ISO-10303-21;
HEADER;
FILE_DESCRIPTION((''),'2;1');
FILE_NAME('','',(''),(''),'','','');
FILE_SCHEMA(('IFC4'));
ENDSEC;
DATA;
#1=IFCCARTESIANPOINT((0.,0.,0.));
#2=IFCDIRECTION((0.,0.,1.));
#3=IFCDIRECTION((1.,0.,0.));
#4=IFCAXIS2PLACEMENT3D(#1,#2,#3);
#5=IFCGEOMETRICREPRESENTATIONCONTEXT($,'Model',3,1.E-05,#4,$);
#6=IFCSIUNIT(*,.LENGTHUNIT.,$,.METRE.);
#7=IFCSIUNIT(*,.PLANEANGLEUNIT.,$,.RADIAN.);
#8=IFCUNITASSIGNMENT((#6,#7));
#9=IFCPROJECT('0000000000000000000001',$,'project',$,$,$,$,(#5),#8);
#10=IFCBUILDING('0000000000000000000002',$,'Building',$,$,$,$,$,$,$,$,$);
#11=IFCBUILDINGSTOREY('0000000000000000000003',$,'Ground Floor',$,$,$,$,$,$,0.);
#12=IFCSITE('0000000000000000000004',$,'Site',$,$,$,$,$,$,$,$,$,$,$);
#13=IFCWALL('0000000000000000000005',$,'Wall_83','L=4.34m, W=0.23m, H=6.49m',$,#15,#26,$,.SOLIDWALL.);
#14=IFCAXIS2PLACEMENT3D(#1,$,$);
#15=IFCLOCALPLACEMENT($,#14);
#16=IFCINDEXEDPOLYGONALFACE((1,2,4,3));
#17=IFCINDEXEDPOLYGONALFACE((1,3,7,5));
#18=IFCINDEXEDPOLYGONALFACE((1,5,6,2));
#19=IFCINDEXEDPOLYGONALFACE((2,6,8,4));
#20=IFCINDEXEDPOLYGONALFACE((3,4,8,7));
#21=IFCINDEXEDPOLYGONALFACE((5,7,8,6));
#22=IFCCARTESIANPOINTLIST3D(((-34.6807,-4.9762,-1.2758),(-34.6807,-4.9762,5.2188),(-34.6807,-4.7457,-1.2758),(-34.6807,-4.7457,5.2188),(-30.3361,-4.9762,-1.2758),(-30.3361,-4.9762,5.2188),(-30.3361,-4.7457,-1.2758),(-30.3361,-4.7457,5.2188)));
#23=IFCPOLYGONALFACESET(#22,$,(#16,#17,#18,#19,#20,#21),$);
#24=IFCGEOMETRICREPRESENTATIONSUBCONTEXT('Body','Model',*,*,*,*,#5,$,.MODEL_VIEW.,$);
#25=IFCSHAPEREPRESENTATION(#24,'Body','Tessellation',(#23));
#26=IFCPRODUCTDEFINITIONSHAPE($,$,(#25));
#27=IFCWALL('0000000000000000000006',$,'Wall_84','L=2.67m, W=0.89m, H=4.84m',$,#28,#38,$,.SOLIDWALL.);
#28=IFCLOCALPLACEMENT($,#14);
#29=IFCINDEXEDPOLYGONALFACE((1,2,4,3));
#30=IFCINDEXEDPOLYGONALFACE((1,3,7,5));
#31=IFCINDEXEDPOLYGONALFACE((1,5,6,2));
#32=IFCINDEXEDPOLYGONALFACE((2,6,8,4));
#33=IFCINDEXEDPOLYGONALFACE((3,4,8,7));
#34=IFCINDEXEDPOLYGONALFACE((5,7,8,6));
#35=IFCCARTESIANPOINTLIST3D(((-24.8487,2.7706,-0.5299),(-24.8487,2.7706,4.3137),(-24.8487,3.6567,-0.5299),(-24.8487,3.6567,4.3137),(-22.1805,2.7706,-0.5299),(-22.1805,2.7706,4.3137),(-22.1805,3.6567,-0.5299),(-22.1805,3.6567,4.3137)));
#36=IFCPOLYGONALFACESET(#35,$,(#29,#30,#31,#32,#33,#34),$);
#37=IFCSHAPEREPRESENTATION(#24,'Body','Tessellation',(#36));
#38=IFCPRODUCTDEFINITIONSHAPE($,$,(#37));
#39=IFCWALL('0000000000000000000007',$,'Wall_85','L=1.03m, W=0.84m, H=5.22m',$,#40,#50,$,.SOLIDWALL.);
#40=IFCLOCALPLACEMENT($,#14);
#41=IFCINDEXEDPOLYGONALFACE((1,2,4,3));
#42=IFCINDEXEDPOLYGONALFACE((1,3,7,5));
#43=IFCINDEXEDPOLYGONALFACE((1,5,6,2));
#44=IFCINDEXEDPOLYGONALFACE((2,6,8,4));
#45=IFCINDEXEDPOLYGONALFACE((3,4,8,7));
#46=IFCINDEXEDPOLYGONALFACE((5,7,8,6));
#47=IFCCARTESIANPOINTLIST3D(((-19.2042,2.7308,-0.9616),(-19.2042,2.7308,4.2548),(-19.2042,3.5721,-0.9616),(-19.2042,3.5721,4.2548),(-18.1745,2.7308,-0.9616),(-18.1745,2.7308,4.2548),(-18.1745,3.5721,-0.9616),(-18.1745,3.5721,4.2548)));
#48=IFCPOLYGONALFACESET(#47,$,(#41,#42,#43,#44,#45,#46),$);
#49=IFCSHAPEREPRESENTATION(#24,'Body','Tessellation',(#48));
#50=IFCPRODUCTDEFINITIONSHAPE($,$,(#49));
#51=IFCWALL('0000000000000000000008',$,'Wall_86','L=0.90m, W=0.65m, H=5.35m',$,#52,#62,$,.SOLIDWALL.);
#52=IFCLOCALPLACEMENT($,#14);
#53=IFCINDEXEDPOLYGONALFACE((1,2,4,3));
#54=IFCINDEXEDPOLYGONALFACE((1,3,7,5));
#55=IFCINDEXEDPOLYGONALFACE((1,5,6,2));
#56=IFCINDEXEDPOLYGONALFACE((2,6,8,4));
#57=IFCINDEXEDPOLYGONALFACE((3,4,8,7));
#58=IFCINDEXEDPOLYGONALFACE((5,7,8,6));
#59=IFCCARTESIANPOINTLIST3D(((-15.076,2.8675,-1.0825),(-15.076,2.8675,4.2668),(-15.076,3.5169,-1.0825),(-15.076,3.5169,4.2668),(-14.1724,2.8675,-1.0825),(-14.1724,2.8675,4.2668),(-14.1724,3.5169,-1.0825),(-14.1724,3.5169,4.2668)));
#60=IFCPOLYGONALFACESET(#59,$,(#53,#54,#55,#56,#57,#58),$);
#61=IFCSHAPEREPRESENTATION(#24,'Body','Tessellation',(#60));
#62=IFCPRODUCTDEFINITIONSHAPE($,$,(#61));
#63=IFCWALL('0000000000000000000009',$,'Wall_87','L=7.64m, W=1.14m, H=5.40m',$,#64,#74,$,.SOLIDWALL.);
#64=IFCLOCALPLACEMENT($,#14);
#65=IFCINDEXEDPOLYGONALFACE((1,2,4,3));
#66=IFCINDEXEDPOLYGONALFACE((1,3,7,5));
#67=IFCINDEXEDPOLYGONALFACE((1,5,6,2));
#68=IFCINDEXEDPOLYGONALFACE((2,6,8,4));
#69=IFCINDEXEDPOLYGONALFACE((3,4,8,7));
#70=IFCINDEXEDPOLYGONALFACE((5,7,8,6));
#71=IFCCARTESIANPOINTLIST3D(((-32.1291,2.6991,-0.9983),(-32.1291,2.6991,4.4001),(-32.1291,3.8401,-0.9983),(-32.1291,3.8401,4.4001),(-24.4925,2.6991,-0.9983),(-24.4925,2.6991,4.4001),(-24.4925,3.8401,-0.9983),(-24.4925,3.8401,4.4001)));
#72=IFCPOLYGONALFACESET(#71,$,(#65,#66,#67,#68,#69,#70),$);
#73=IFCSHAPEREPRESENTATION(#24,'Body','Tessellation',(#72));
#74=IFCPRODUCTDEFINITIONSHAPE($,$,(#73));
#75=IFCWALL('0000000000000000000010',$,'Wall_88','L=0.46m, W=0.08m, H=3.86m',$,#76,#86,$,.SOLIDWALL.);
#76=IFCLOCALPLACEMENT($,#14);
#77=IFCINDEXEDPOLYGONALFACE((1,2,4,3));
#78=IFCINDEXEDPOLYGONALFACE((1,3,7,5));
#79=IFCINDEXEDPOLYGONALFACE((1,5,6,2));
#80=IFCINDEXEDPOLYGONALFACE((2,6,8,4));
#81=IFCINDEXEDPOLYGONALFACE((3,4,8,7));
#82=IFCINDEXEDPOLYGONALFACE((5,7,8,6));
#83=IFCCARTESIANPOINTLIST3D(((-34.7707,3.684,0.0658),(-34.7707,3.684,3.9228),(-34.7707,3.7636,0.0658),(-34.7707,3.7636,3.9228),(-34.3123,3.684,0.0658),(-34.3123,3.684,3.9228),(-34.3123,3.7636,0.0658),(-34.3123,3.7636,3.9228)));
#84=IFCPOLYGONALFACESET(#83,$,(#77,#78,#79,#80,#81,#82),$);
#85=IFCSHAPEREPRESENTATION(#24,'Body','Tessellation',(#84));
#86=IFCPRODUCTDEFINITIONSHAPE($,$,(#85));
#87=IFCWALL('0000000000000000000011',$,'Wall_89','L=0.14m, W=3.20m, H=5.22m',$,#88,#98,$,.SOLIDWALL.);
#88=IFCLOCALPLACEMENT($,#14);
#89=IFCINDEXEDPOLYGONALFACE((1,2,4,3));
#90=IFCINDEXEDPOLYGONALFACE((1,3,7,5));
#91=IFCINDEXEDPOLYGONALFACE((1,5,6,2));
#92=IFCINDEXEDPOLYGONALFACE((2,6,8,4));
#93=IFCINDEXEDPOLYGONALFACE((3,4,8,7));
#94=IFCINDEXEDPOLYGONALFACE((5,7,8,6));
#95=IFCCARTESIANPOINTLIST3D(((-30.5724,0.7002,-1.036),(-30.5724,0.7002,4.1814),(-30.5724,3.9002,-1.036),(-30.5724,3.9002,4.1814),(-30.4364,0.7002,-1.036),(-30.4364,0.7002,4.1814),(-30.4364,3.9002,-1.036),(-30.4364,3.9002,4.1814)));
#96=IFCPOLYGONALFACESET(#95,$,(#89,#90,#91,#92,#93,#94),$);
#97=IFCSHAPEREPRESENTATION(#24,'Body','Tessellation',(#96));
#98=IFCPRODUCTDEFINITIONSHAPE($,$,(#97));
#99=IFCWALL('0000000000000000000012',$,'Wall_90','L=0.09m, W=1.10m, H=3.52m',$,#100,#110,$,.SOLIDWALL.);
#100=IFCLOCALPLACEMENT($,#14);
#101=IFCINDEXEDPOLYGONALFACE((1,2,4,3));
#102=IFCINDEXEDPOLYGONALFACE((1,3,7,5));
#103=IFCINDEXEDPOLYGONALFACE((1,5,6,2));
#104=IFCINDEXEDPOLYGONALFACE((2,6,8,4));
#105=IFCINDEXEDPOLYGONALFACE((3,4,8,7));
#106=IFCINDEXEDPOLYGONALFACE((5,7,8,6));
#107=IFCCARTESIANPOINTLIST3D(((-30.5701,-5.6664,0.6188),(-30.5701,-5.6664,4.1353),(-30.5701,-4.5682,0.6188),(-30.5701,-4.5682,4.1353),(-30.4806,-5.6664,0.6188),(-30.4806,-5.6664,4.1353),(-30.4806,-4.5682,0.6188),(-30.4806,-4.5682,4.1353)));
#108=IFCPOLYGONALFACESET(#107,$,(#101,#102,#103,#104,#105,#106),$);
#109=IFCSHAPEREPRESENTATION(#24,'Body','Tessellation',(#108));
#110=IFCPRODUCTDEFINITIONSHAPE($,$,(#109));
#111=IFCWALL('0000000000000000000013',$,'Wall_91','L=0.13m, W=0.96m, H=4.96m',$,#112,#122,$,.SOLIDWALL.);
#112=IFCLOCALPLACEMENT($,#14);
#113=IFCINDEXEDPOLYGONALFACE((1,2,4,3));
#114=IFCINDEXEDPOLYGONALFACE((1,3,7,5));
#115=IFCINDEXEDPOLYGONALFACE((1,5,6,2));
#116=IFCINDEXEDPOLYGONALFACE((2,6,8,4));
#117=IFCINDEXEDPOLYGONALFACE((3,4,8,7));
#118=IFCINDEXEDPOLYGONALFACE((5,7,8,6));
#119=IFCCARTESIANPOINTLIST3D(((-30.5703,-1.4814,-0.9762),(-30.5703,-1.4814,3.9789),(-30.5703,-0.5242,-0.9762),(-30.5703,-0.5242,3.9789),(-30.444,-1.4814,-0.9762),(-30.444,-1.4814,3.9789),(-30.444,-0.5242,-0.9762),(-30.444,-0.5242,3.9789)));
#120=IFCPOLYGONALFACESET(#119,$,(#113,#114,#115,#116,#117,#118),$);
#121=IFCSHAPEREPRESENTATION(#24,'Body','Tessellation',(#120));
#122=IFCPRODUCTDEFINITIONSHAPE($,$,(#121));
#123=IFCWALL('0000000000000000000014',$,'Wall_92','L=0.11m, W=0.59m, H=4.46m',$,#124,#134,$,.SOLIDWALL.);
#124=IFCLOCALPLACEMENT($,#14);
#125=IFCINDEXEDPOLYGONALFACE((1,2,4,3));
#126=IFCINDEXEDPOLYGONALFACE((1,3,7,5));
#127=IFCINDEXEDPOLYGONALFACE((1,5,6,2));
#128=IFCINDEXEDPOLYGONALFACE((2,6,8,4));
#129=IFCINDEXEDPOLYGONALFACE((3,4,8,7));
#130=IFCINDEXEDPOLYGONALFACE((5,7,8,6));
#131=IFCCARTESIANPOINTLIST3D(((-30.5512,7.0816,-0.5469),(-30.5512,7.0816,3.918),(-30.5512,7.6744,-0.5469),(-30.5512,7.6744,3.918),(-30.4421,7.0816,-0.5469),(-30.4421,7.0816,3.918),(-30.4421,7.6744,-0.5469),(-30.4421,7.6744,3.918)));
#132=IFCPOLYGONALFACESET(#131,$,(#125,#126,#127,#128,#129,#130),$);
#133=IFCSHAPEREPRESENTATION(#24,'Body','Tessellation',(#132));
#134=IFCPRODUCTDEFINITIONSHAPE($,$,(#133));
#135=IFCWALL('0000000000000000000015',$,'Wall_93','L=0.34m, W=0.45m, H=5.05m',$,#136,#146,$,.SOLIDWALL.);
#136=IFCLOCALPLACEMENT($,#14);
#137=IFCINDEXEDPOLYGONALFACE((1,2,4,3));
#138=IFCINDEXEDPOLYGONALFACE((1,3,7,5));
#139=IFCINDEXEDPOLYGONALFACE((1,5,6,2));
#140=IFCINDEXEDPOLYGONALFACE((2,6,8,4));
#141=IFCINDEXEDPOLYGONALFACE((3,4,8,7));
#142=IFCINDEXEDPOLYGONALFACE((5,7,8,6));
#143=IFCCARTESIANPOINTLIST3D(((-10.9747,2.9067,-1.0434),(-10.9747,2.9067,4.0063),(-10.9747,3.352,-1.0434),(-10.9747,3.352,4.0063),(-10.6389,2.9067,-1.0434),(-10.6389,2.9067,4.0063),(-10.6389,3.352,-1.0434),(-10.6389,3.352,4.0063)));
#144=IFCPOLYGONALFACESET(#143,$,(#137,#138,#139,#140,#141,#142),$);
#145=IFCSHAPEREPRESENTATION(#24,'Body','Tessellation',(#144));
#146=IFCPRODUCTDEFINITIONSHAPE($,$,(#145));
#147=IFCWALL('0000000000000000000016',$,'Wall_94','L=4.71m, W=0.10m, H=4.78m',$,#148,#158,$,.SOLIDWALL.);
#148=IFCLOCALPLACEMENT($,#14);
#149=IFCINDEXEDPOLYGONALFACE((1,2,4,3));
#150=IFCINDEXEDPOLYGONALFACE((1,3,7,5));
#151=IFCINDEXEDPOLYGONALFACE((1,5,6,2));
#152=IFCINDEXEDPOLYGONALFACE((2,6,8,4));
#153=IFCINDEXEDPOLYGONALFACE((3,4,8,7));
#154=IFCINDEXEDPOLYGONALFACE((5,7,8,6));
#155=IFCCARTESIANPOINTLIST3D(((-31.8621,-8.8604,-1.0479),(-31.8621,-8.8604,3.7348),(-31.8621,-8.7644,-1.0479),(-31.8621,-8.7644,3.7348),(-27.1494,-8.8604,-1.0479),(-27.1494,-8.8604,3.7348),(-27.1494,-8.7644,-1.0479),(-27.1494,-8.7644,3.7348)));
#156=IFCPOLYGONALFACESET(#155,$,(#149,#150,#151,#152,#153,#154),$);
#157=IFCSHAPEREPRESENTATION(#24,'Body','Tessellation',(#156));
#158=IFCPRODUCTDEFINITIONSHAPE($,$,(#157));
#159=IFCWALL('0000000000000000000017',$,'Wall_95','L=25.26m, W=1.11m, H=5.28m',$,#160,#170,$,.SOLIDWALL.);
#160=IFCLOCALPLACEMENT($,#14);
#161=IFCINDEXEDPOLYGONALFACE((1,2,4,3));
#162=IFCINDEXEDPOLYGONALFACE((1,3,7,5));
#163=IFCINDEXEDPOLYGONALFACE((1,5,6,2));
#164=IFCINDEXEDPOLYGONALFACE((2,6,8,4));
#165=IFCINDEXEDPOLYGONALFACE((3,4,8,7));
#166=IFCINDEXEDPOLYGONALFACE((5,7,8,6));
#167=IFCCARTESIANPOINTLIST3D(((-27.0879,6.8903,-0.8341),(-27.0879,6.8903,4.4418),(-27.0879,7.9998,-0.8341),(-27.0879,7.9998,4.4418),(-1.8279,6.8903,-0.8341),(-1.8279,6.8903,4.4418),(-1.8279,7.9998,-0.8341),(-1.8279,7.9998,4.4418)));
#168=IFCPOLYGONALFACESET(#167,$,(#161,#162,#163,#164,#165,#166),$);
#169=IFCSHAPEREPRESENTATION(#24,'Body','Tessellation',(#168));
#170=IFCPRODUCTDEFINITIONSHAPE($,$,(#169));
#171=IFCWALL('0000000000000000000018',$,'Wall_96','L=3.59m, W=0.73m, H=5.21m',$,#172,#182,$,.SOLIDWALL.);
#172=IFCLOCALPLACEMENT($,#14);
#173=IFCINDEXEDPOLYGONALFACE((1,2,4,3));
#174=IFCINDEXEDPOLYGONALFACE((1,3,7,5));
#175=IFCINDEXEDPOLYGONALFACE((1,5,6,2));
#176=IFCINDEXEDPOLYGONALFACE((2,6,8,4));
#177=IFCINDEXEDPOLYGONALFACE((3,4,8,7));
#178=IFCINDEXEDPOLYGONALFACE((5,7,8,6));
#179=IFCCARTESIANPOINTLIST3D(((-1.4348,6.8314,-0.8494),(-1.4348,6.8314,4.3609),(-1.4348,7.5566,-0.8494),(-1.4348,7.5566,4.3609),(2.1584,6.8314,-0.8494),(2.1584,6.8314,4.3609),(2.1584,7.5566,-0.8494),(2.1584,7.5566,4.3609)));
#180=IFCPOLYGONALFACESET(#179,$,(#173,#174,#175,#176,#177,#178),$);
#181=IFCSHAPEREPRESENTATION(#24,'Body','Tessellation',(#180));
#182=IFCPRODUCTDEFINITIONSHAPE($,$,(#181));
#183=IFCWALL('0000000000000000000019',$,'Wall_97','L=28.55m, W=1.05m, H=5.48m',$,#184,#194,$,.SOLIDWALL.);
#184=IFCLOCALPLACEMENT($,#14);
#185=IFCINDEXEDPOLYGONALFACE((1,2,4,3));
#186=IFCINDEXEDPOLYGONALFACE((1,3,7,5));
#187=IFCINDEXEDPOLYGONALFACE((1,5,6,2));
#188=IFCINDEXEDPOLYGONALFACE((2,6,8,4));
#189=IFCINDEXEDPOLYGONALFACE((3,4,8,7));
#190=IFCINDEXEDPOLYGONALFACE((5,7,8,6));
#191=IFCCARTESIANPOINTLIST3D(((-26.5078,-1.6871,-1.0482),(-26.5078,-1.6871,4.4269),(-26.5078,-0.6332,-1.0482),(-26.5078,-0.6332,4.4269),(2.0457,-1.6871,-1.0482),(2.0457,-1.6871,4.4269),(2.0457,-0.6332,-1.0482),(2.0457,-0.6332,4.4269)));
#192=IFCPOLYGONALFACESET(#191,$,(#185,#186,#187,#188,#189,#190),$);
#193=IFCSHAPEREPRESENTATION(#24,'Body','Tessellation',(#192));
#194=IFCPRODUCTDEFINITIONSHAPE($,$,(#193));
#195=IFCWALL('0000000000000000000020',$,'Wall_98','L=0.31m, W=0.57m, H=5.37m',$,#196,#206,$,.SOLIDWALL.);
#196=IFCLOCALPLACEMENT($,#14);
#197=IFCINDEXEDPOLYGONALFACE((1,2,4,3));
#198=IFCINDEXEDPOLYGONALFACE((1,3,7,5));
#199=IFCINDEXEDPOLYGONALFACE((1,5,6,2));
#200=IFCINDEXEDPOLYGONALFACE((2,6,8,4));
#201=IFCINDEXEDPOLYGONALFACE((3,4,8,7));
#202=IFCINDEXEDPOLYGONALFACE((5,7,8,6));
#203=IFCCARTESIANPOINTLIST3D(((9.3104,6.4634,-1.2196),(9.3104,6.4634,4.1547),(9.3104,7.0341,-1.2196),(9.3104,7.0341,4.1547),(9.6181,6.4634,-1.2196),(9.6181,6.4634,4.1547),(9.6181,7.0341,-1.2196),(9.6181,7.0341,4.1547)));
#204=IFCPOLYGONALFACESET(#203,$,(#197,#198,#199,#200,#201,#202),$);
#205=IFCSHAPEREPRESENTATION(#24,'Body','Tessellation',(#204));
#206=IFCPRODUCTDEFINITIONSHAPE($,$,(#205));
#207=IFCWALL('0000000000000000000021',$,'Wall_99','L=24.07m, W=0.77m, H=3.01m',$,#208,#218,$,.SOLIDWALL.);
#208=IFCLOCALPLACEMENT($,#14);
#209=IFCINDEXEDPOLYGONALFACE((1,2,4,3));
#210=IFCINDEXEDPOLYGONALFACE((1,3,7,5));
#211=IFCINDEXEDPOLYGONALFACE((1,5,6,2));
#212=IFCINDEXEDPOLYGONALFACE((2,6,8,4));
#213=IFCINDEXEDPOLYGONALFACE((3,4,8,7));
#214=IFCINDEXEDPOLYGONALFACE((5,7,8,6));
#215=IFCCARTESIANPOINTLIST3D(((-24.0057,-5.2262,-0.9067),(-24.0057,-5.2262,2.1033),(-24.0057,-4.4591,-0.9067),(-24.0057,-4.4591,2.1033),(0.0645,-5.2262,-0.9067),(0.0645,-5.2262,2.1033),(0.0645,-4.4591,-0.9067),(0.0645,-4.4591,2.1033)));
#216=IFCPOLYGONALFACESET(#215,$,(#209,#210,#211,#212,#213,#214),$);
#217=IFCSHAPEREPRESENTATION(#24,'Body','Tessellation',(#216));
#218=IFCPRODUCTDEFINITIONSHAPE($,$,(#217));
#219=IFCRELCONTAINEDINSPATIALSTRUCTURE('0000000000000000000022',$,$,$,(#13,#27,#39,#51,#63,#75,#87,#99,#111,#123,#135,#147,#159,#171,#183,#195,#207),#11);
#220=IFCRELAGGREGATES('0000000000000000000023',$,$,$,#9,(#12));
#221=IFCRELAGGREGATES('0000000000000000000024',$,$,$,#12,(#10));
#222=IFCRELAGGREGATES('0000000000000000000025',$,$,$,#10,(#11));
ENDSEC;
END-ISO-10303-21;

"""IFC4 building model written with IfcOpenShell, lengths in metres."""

from ifc_helpers import new_model, si_unit, frame, origin_with_axes, origin_2d, context, subcontext, project, spatial, rectangle, extrude, element, save


model = new_model("IFC4")

# Units and contexts
model_context = context("Model", 3, precision=1e-05, world=origin_with_axes())
body_context = subcontext(model_context, "Body", "Model", "MODEL_VIEW")
ifc_project = project(units=[si_unit("LENGTHUNIT", "METRE"), si_unit("PLANEANGLEUNIT", "RADIAN")], contexts=[model_context])

# Site, building, storey
site = spatial("IfcSite", under=ifc_project, Name="Site")
building = spatial("IfcBuilding", under=site, Name="Building")
storey = spatial("IfcBuildingStorey", under=building, Name="Ground Floor", Elevation=0.0)

# Walls
element("IfcWall", 1, inside=storey, Name="Wall_83", Description="L=4.34m, W=0.23m, H=6.49m", PredefinedType="SOLIDWALL", context=body_context, shape_type="SweptSolid", body=[
    extrude(rectangle(XDim=4.3446, YDim=0.2305, at=origin_2d()), frame((-32.5084, -4.861, -1.2758), z_axis=(0.0, 0.0, 1.0), x_axis=(1.0, 0.0, 0.0)), (0.0, 0.0, 1.0), 6.4946),
])
element("IfcWall", 2, inside=storey, Name="Wall_84", Description="L=2.67m, W=0.89m, H=4.84m", PredefinedType="SOLIDWALL", context=body_context, shape_type="SweptSolid", body=[
    extrude(rectangle(XDim=2.6682, YDim=0.8861, at=origin_2d()), frame((-23.5146, 3.2136, -0.5299), z_axis=(0.0, 0.0, 1.0), x_axis=(1.0, 0.0, 0.0)), (0.0, 0.0, 1.0), 4.8436),
])
element("IfcWall", 3, inside=storey, Name="Wall_85", Description="L=1.03m, W=0.84m, H=5.22m", PredefinedType="SOLIDWALL", context=body_context, shape_type="SweptSolid", body=[
    extrude(rectangle(XDim=1.0297, YDim=0.8412, at=origin_2d()), frame((-18.6894, 3.1514, -0.9616), z_axis=(0.0, 0.0, 1.0), x_axis=(1.0, 0.0, 0.0)), (0.0, 0.0, 1.0), 5.2164),
])
element("IfcWall", 4, inside=storey, Name="Wall_86", Description="L=0.90m, W=0.65m, H=5.35m", PredefinedType="SOLIDWALL", context=body_context, shape_type="SweptSolid", body=[
    extrude(rectangle(XDim=0.9035, YDim=0.6494, at=origin_2d()), frame((-14.6242, 3.1922, -1.0825), z_axis=(0.0, 0.0, 1.0), x_axis=(1.0, 0.0, 0.0)), (0.0, 0.0, 1.0), 5.3493),
])
element("IfcWall", 5, inside=storey, Name="Wall_87", Description="L=7.64m, W=1.14m, H=5.40m", PredefinedType="SOLIDWALL", context=body_context, shape_type="SweptSolid", body=[
    extrude(rectangle(XDim=7.6367, YDim=1.1411, at=origin_2d()), frame((-28.3108, 3.2696, -0.9983), z_axis=(0.0, 0.0, 1.0), x_axis=(1.0, 0.0, 0.0)), (0.0, 0.0, 1.0), 5.3984),
])
element("IfcWall", 6, inside=storey, Name="Wall_88", Description="L=0.46m, W=0.08m, H=3.86m", PredefinedType="SOLIDWALL", context=body_context, shape_type="SweptSolid", body=[
    extrude(rectangle(XDim=0.4584, YDim=0.0796, at=origin_2d()), frame((-34.5415, 3.7238, 0.0658), z_axis=(0.0, 0.0, 1.0), x_axis=(1.0, 0.0, 0.0)), (0.0, 0.0, 1.0), 3.857),
])
element("IfcWall", 7, inside=storey, Name="Wall_89", Description="L=0.14m, W=3.20m, H=5.22m", PredefinedType="SOLIDWALL", context=body_context, shape_type="SweptSolid", body=[
    extrude(rectangle(XDim=0.136, YDim=3.2, at=origin_2d()), frame((-30.5044, 2.3002, -1.036), z_axis=(0.0, 0.0, 1.0), x_axis=(1.0, 0.0, 0.0)), (0.0, 0.0, 1.0), 5.2174),
])
element("IfcWall", 8, inside=storey, Name="Wall_90", Description="L=0.09m, W=1.10m, H=3.52m", PredefinedType="SOLIDWALL", context=body_context, shape_type="SweptSolid", body=[
    extrude(rectangle(XDim=0.0895, YDim=1.0983, at=origin_2d()), frame((-30.5254, -5.1173, 0.6188), z_axis=(0.0, 0.0, 1.0), x_axis=(1.0, 0.0, 0.0)), (0.0, 0.0, 1.0), 3.5166),
])
element("IfcWall", 9, inside=storey, Name="Wall_91", Description="L=0.13m, W=0.96m, H=4.96m", PredefinedType="SOLIDWALL", context=body_context, shape_type="SweptSolid", body=[
    extrude(rectangle(XDim=0.1263, YDim=0.9571, at=origin_2d()), frame((-30.5071, -1.0028, -0.9762), z_axis=(0.0, 0.0, 1.0), x_axis=(1.0, 0.0, 0.0)), (0.0, 0.0, 1.0), 4.9551),
])
element("IfcWall", 10, inside=storey, Name="Wall_92", Description="L=0.11m, W=0.59m, H=4.46m", PredefinedType="SOLIDWALL", context=body_context, shape_type="SweptSolid", body=[
    extrude(rectangle(XDim=0.1091, YDim=0.5928, at=origin_2d()), frame((-30.4967, 7.378, -0.5469), z_axis=(0.0, 0.0, 1.0), x_axis=(1.0, 0.0, 0.0)), (0.0, 0.0, 1.0), 4.4649),
])
element("IfcWall", 11, inside=storey, Name="Wall_93", Description="L=0.34m, W=0.45m, H=5.05m", PredefinedType="SOLIDWALL", context=body_context, shape_type="SweptSolid", body=[
    extrude(rectangle(XDim=0.3358, YDim=0.4454, at=origin_2d()), frame((-10.8068, 3.1293, -1.0434), z_axis=(0.0, 0.0, 1.0), x_axis=(1.0, 0.0, 0.0)), (0.0, 0.0, 1.0), 5.0497),
])
element("IfcWall", 12, inside=storey, Name="Wall_94", Description="L=4.71m, W=0.10m, H=4.78m", PredefinedType="SOLIDWALL", context=body_context, shape_type="SweptSolid", body=[
    extrude(rectangle(XDim=4.7127, YDim=0.0959, at=origin_2d()), frame((-29.5058, -8.8124, -1.0479), z_axis=(0.0, 0.0, 1.0), x_axis=(1.0, 0.0, 0.0)), (0.0, 0.0, 1.0), 4.7827),
])
element("IfcWall", 13, inside=storey, Name="Wall_95", Description="L=25.26m, W=1.11m, H=5.28m", PredefinedType="SOLIDWALL", context=body_context, shape_type="SweptSolid", body=[
    extrude(rectangle(XDim=25.26, YDim=1.1095, at=origin_2d()), frame((-14.4579, 7.4451, -0.8341), z_axis=(0.0, 0.0, 1.0), x_axis=(1.0, 0.0, 0.0)), (0.0, 0.0, 1.0), 5.276),
])
element("IfcWall", 14, inside=storey, Name="Wall_96", Description="L=3.59m, W=0.73m, H=5.21m", PredefinedType="SOLIDWALL", context=body_context, shape_type="SweptSolid", body=[
    extrude(rectangle(XDim=3.5931, YDim=0.7253, at=origin_2d()), frame((0.3618, 7.194, -0.8494), z_axis=(0.0, 0.0, 1.0), x_axis=(1.0, 0.0, 0.0)), (0.0, 0.0, 1.0), 5.2103),
])
element("IfcWall", 15, inside=storey, Name="Wall_97", Description="L=28.55m, W=1.05m, H=5.48m", PredefinedType="SOLIDWALL", context=body_context, shape_type="SweptSolid", body=[
    extrude(rectangle(XDim=28.5534, YDim=1.0539, at=origin_2d()), frame((-12.231, -1.1601, -1.0482), z_axis=(0.0, 0.0, 1.0), x_axis=(1.0, 0.0, 0.0)), (0.0, 0.0, 1.0), 5.4752),
])
element("IfcWall", 16, inside=storey, Name="Wall_98", Description="L=0.31m, W=0.57m, H=5.37m", PredefinedType="SOLIDWALL", context=body_context, shape_type="SweptSolid", body=[
    extrude(rectangle(XDim=0.3077, YDim=0.5707, at=origin_2d()), frame((9.4642, 6.7487, -1.2196), z_axis=(0.0, 0.0, 1.0), x_axis=(1.0, 0.0, 0.0)), (0.0, 0.0, 1.0), 5.3743),
])
element("IfcWall", 17, inside=storey, Name="Wall_99", Description="L=24.07m, W=0.77m, H=3.01m", PredefinedType="SOLIDWALL", context=body_context, shape_type="SweptSolid", body=[
    extrude(rectangle(XDim=24.0702, YDim=0.7671, at=origin_2d()), frame((-11.9706, -4.8426, -0.9067), z_axis=(0.0, 0.0, 1.0), x_axis=(1.0, 0.0, 0.0)), (0.0, 0.0, 1.0), 3.01),
])

save(model, "model.ifc")
